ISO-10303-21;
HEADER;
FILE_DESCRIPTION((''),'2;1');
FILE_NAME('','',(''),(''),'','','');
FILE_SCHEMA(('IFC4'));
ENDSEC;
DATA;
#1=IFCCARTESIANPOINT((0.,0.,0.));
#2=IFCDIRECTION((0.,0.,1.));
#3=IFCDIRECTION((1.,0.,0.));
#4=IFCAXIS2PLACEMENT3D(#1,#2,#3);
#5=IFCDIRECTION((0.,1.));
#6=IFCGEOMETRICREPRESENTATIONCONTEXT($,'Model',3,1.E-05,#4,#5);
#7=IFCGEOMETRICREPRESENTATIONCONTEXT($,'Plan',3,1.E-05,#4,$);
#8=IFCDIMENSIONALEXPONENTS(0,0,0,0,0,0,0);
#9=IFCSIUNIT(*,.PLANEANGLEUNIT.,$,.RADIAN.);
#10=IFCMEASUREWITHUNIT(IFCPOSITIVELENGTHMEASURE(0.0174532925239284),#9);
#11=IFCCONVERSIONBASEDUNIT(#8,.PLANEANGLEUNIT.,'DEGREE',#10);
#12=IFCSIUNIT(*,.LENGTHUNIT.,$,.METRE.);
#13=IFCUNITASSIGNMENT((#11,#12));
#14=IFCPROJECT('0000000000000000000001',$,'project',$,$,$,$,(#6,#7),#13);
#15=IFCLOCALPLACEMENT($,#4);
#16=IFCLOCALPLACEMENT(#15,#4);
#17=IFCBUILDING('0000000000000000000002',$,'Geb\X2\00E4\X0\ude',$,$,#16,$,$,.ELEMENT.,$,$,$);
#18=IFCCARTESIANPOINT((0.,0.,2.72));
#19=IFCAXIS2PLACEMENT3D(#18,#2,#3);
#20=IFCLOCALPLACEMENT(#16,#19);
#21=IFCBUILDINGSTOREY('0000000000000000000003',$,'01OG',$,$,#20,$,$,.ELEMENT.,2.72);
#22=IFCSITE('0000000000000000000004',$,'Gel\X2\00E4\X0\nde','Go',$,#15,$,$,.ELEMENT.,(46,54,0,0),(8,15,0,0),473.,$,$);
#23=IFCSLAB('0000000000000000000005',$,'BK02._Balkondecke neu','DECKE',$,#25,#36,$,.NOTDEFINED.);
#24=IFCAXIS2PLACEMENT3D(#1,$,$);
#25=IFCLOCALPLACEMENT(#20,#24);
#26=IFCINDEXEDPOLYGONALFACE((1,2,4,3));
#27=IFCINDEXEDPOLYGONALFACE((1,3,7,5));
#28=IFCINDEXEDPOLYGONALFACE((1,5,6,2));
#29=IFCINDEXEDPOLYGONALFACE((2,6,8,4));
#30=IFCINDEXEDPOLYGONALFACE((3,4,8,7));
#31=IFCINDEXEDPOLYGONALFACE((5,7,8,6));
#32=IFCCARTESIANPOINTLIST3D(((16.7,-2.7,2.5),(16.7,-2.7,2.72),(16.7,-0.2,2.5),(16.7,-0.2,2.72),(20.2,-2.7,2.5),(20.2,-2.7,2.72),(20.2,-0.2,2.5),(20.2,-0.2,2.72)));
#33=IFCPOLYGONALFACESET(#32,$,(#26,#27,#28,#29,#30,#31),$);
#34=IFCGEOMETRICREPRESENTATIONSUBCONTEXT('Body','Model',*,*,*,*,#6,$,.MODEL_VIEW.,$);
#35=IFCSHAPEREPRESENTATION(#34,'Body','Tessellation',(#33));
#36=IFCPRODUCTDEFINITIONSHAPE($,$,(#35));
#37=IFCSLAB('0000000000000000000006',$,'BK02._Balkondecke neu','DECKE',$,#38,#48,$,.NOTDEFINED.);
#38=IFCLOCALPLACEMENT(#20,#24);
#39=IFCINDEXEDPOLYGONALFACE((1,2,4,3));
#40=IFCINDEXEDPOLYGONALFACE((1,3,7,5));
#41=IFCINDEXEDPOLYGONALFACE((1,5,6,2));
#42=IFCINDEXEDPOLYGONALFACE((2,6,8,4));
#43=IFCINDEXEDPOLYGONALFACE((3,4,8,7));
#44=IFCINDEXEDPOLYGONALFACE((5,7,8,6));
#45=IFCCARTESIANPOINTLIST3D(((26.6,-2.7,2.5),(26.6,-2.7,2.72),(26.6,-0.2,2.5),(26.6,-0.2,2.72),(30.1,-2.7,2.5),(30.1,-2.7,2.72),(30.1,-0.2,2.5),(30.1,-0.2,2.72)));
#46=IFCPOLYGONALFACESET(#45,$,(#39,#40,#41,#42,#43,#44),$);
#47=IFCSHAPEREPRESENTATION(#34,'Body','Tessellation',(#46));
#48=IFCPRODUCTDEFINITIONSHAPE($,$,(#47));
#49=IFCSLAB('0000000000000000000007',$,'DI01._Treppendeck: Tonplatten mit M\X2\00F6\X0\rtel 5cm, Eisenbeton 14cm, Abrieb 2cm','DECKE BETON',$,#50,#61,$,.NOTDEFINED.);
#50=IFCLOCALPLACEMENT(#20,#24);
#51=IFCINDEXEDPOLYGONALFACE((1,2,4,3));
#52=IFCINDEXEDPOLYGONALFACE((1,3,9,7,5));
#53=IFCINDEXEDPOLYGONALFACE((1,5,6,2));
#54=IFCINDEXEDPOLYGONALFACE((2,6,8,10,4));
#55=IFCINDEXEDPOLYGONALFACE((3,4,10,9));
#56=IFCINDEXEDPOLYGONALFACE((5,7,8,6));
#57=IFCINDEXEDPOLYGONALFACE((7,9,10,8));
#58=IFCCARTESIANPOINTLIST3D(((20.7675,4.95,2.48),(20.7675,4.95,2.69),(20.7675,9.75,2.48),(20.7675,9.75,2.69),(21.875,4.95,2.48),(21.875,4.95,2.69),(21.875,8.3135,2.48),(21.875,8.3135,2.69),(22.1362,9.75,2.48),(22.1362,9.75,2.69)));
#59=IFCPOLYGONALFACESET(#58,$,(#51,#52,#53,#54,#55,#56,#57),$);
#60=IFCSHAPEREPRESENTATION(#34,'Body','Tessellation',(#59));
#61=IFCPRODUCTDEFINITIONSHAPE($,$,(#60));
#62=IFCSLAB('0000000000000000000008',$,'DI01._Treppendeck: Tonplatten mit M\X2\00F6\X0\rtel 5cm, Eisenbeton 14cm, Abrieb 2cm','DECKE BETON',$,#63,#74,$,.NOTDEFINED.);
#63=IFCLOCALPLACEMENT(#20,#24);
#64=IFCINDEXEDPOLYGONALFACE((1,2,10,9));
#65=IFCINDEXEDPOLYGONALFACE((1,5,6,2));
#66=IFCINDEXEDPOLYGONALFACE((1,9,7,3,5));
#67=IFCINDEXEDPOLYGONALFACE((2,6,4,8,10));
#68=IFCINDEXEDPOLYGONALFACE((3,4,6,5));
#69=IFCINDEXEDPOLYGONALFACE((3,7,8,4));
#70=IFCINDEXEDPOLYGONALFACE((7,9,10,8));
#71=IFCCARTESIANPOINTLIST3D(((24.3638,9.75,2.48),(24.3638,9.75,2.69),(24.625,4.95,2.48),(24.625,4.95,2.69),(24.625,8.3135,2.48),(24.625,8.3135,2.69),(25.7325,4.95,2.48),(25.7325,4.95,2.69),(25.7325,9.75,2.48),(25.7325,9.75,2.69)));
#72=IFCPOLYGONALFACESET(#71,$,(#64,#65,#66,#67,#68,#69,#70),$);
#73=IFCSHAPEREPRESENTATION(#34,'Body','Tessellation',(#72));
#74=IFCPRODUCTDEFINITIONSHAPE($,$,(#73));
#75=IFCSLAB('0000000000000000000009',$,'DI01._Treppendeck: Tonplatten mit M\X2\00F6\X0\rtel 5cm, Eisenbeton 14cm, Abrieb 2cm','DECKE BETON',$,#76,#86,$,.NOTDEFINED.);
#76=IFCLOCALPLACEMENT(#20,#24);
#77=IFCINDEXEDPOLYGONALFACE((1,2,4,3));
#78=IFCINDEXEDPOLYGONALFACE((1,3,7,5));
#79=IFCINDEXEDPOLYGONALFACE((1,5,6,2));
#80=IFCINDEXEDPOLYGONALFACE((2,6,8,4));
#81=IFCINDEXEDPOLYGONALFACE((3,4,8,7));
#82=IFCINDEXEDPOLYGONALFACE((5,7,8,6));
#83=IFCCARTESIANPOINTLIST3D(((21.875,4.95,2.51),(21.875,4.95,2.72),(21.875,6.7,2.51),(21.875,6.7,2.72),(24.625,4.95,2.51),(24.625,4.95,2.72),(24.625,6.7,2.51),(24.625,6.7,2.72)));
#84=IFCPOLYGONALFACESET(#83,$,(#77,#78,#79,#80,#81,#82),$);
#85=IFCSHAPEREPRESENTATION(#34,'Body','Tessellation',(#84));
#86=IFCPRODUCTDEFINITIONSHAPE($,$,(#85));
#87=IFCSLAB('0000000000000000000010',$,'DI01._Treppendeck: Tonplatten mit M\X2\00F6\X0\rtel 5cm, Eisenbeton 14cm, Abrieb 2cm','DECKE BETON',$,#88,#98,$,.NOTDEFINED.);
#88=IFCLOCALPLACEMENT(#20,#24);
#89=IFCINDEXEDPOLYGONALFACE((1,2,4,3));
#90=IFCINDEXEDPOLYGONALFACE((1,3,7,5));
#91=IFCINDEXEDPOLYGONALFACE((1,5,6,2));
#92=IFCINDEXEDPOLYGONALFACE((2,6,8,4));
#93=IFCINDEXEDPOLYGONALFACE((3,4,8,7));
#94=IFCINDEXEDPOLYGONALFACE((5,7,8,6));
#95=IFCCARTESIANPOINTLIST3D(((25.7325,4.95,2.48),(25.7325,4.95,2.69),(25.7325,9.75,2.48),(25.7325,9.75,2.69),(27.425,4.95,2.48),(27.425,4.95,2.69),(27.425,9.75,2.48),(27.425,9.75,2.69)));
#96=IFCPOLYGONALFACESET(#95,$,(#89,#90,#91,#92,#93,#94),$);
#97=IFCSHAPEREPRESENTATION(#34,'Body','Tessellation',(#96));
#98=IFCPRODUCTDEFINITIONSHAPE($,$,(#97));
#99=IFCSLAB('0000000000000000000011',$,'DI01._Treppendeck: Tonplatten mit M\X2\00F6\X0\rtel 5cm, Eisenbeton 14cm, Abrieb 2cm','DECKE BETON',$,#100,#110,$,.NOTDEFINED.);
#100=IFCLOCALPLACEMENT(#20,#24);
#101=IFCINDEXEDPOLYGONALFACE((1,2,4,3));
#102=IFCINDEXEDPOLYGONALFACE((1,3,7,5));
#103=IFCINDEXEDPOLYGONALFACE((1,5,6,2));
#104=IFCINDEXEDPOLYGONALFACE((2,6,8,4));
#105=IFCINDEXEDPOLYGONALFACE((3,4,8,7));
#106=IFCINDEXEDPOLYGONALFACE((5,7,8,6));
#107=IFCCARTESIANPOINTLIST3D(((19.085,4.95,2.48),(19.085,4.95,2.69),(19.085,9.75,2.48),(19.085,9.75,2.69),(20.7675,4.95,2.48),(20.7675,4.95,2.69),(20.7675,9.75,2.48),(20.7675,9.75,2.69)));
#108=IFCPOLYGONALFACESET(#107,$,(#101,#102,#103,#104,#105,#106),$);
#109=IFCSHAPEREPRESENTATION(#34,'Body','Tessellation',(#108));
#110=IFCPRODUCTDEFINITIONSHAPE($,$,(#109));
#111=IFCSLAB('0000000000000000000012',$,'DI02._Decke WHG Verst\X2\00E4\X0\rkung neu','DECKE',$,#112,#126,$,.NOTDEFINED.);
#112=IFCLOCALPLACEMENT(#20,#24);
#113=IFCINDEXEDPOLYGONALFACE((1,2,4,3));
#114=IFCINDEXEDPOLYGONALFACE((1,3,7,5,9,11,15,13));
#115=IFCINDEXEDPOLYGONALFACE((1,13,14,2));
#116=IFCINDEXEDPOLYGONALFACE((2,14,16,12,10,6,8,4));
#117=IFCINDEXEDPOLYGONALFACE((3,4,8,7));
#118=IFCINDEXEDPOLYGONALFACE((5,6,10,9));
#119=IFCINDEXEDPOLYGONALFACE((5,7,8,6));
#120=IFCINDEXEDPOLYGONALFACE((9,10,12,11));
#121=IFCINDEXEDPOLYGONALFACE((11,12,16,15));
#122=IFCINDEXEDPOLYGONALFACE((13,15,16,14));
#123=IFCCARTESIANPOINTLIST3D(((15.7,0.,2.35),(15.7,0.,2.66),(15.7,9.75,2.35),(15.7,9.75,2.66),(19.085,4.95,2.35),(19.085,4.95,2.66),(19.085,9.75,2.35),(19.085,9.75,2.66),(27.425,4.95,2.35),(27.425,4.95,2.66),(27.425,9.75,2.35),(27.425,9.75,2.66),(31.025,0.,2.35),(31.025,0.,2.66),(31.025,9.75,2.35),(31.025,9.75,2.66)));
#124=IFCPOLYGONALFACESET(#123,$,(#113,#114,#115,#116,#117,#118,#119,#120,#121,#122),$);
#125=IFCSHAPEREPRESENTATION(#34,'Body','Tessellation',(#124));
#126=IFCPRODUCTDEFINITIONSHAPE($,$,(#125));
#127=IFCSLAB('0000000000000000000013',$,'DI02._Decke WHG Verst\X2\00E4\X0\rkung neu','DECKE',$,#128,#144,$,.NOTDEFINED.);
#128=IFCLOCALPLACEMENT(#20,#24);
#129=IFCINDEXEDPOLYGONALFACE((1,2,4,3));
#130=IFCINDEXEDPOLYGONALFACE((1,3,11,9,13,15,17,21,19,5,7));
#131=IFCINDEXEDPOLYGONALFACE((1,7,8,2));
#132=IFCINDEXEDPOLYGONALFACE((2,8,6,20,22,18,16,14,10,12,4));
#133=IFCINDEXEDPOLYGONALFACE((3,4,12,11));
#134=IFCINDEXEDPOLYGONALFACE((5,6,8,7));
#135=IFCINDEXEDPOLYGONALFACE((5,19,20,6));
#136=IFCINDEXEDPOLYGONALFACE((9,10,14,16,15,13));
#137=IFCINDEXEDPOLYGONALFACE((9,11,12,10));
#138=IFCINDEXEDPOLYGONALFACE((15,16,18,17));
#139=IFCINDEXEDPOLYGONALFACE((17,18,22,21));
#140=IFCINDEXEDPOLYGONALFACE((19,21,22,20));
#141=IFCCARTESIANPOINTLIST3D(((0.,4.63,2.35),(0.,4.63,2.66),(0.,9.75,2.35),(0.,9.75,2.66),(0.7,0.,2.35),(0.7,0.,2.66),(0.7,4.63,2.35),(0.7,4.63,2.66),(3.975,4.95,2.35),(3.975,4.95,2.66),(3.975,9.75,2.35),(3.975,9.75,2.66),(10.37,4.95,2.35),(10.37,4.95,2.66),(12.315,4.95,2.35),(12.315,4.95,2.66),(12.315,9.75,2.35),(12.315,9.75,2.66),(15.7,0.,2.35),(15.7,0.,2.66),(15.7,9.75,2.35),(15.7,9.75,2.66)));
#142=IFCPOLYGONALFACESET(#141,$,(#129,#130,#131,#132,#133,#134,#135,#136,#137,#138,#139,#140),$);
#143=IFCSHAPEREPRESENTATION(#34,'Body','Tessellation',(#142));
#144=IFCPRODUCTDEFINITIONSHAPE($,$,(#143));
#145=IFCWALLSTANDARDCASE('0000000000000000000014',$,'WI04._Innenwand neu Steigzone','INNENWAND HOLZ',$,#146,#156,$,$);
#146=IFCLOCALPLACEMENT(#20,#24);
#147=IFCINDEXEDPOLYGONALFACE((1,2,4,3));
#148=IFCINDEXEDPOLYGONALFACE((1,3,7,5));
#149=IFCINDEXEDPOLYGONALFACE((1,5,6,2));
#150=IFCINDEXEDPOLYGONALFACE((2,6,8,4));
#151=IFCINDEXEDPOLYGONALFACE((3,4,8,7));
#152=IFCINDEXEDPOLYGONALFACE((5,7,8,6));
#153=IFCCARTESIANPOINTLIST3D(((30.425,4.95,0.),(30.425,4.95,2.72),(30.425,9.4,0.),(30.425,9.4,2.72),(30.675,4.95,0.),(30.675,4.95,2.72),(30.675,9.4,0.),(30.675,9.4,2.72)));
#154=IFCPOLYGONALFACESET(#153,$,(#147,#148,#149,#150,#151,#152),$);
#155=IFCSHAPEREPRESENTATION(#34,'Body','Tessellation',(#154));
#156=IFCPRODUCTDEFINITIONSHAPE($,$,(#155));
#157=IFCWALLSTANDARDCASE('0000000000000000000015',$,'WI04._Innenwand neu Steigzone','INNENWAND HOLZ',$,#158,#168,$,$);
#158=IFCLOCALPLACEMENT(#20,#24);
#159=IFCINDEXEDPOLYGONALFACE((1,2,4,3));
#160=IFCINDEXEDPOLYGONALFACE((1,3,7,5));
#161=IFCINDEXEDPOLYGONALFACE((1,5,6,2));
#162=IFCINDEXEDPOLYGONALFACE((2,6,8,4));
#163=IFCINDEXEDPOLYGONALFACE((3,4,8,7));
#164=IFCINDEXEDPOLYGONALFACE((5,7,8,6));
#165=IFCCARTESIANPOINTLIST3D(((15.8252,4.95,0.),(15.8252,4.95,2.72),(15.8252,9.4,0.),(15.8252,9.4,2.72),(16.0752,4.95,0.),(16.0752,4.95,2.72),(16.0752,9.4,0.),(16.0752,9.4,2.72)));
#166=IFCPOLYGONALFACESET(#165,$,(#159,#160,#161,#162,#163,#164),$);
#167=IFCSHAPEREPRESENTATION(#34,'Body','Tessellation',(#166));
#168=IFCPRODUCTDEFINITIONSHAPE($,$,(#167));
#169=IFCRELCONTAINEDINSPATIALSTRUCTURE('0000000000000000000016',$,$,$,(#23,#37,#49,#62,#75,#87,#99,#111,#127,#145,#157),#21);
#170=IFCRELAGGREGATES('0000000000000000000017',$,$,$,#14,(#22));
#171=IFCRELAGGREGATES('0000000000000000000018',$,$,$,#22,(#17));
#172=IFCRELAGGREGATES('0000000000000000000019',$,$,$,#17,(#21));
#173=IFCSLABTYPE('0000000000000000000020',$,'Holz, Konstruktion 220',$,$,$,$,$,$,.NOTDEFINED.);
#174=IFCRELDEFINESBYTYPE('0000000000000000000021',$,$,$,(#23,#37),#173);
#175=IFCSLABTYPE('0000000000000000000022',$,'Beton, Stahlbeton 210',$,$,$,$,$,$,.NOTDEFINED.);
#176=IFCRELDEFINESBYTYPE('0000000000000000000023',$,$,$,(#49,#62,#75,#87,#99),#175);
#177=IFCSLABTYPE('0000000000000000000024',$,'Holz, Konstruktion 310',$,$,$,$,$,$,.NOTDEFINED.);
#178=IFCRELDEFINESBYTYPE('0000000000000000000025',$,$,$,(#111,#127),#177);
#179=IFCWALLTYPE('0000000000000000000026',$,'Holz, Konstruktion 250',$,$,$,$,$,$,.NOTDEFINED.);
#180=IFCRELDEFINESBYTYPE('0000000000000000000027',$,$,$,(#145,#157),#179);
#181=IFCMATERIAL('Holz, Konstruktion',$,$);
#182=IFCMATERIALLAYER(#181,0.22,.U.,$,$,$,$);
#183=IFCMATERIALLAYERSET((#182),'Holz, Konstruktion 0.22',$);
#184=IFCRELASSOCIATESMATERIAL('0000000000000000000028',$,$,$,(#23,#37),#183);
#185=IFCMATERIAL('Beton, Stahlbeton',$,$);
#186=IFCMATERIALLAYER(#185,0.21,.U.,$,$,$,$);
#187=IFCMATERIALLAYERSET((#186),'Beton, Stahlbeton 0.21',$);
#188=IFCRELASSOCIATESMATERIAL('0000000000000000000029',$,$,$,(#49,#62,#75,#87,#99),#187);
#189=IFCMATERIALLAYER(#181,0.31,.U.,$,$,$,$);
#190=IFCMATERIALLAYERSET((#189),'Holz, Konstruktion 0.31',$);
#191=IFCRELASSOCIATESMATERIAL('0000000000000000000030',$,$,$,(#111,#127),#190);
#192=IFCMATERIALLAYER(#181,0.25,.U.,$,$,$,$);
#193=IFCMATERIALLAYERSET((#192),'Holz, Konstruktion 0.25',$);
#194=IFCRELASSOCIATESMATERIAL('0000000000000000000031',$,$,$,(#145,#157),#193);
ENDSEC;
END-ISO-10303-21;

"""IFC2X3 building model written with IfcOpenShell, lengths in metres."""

from ifc_helpers import new_model, entity, si_unit, converted_unit, direction, frame, origin_with_axes, place, context, subcontext, project, spatial, polyline, outline, extrude, material, layer, layer_set, layer_usage, type_object, element, save


model = new_model("IFC2X3")

# Units and contexts
model_context = context("Model", 3, precision=1e-05, world=origin_with_axes(), true_north=direction((0.0, 1.0)))
plan_context = context("Plan", 3, precision=1e-05, world=origin_with_axes())
body_context = subcontext(model_context, "Body", "Model", "MODEL_VIEW")
ifc_project = project(units=[converted_unit("PLANEANGLEUNIT", "DEGREE", entity("IfcPositiveLengthMeasure", 0.0174532925239284), si_unit("PLANEANGLEUNIT", "RADIAN"), dimensions=[0, 0, 0, 0, 0, 0, 0]), si_unit("LENGTHUNIT", "METRE")], contexts=[model_context, plan_context])

# Site, building, storey
site_placement = place(None, origin_with_axes())
site = spatial("IfcSite", under=ifc_project, at=site_placement, Name="Gelände", Description="Go", CompositionType="ELEMENT", RefLatitude=(46, 54, 0, 0), RefLongitude=(8, 15, 0, 0), RefElevation=473.0)
building_placement = place(site_placement, origin_with_axes())
building = spatial("IfcBuilding", under=site, at=building_placement, Name="Gebäude", CompositionType="ELEMENT")
storey_placement = place(building_placement, frame((0.0, 0.0, 2.72), z_axis=(0.0, 0.0, 1.0), x_axis=(1.0, 0.0, 0.0)))
storey = spatial("IfcBuildingStorey", under=building, at=storey_placement, Name="01OG", CompositionType="ELEMENT", Elevation=2.72)

# Slabs
ifc_material_1 = material(Name="Holz, Konstruktion")
ifc_layer_1 = layer(ifc_material_1, 0.22, ventilated="UNKNOWN")
ifc_layer_set_1 = layer_set([ifc_layer_1], Name="Holz, Konstruktion 0.22")
ifc_layer_usage_1 = layer_usage(ifc_layer_set_1, "AXIS3", "NEGATIVE", 0.22)
slab_type_1 = type_object("IfcSlabType", Name="Holz, Konstruktion 220", PredefinedType="NOTDEFINED")
slab_1_placement = place(storey_placement, frame((16.7, -2.7, 2.72), z_axis=(0.0, 0.0, 1.0), x_axis=(1.0, 0.0, 0.0)))
element("IfcSlab", 1, at=slab_1_placement, inside=storey, type_object=slab_type_1, material=ifc_layer_usage_1, Name="BK02._Balkondecke neu", Description="DECKE", PredefinedType="NOTDEFINED", context=body_context, shape_type="SweptSolid", body=[
    extrude(outline(polyline([(0.0, 0.0), (3.5, 0.0), (3.5, 2.5), (0.0, 2.5), (0.0, 0.0)])), frame((0.0, 0.0, -0.22), z_axis=(0.0, 0.0, 1.0), x_axis=(1.0, 0.0, 0.0)), (0.0, 0.0, 1.0), 0.22),
])
ifc_layer_usage_2 = layer_usage(ifc_layer_set_1, "AXIS3", "NEGATIVE", 0.22)
slab_2_placement = place(storey_placement, frame((26.6, -2.7, 2.72), z_axis=(0.0, 0.0, 1.0), x_axis=(1.0, 0.0, 0.0)))
element("IfcSlab", 2, at=slab_2_placement, inside=storey, type_object=slab_type_1, material=ifc_layer_usage_2, Name="BK02._Balkondecke neu", Description="DECKE", PredefinedType="NOTDEFINED", context=body_context, shape_type="SweptSolid", body=[
    extrude(outline(polyline([(0.0, 0.0), (3.5, 0.0), (3.5, 2.5), (0.0, 2.5), (0.0, 0.0)])), frame((0.0, 0.0, -0.22), z_axis=(0.0, 0.0, 1.0), x_axis=(1.0, 0.0, 0.0)), (0.0, 0.0, 1.0), 0.22),
])
ifc_material_2 = material(Name="Beton, Stahlbeton")
ifc_layer_2 = layer(ifc_material_2, 0.21, ventilated="UNKNOWN")
ifc_layer_set_2 = layer_set([ifc_layer_2], Name="Beton, Stahlbeton 0.21")
ifc_layer_usage_3 = layer_usage(ifc_layer_set_2, "AXIS3", "NEGATIVE", 0.21)
slab_type_2 = type_object("IfcSlabType", Name="Beton, Stahlbeton 210", PredefinedType="NOTDEFINED")
slab_3_placement = place(storey_placement, frame((20.7675, 4.95, 2.69), z_axis=(0.0, 0.0, 1.0), x_axis=(1.0, 0.0, 0.0)))
element("IfcSlab", 3, at=slab_3_placement, inside=storey, type_object=slab_type_2, material=ifc_layer_usage_3, Name="DI01._Treppendeck: Tonplatten mit Mörtel 5cm, Eisenbeton 14cm, Abrieb 2cm", Description="DECKE BETON", PredefinedType="NOTDEFINED", context=body_context, shape_type="SweptSolid", body=[
    extrude(outline(polyline([(0.0, 0.0), (1.1075, 0.0), (1.1075, 3.3635), (1.3687, 4.8), (0.0, 4.8), (0.0, 0.0)])), frame((0.0, 0.0, -0.21), z_axis=(0.0, 0.0, 1.0), x_axis=(1.0, 0.0, 0.0)), (0.0, 0.0, 1.0), 0.21),
])
ifc_layer_usage_4 = layer_usage(ifc_layer_set_2, "AXIS3", "NEGATIVE", 0.21)
slab_4_placement = place(storey_placement, frame((24.625, 4.95, 2.69), z_axis=(0.0, 0.0, 1.0), x_axis=(1.0, 0.0, 0.0)))
element("IfcSlab", 4, at=slab_4_placement, inside=storey, type_object=slab_type_2, material=ifc_layer_usage_4, Name="DI01._Treppendeck: Tonplatten mit Mörtel 5cm, Eisenbeton 14cm, Abrieb 2cm", Description="DECKE BETON", PredefinedType="NOTDEFINED", context=body_context, shape_type="SweptSolid", body=[
    extrude(outline(polyline([(0.0, 0.0), (1.1075, 0.0), (1.1075, 4.8), (-0.2612, 4.8), (0.0, 3.3635), (0.0, 0.0)])), frame((0.0, 0.0, -0.21), z_axis=(0.0, 0.0, 1.0), x_axis=(1.0, 0.0, 0.0)), (0.0, 0.0, 1.0), 0.21),
])
ifc_layer_usage_5 = layer_usage(ifc_layer_set_2, "AXIS3", "NEGATIVE", 0.21)
slab_5_placement = place(storey_placement, frame((21.875, 4.95, 2.72), z_axis=(0.0, 0.0, 1.0), x_axis=(1.0, 0.0, 0.0)))
element("IfcSlab", 5, at=slab_5_placement, inside=storey, type_object=slab_type_2, material=ifc_layer_usage_5, Name="DI01._Treppendeck: Tonplatten mit Mörtel 5cm, Eisenbeton 14cm, Abrieb 2cm", Description="DECKE BETON", PredefinedType="NOTDEFINED", context=body_context, shape_type="SweptSolid", body=[
    extrude(outline(polyline([(0.0, 0.0), (2.75, 0.0), (2.75, 1.75), (0.0, 1.75), (0.0, 0.0)])), frame((0.0, 0.0, -0.21), z_axis=(0.0, 0.0, 1.0), x_axis=(1.0, 0.0, 0.0)), (0.0, 0.0, 1.0), 0.21),
])
ifc_layer_usage_6 = layer_usage(ifc_layer_set_2, "AXIS3", "NEGATIVE", 0.21)
slab_6_placement = place(storey_placement, frame((25.7325, 4.95, 2.69), z_axis=(0.0, 0.0, 1.0), x_axis=(1.0, 0.0, 0.0)))
element("IfcSlab", 6, at=slab_6_placement, inside=storey, type_object=slab_type_2, material=ifc_layer_usage_6, Name="DI01._Treppendeck: Tonplatten mit Mörtel 5cm, Eisenbeton 14cm, Abrieb 2cm", Description="DECKE BETON", PredefinedType="NOTDEFINED", context=body_context, shape_type="SweptSolid", body=[
    extrude(outline(polyline([(0.0, 0.0), (1.6925, 0.0), (1.6925, 4.8), (0.0, 4.8), (0.0, 0.0)])), frame((0.0, 0.0, -0.21), z_axis=(0.0, 0.0, 1.0), x_axis=(1.0, 0.0, 0.0)), (0.0, 0.0, 1.0), 0.21),
])
ifc_layer_usage_7 = layer_usage(ifc_layer_set_2, "AXIS3", "NEGATIVE", 0.21)
slab_7_placement = place(storey_placement, frame((19.085, 4.95, 2.69), z_axis=(0.0, 0.0, 1.0), x_axis=(1.0, 0.0, 0.0)))
element("IfcSlab", 7, at=slab_7_placement, inside=storey, type_object=slab_type_2, material=ifc_layer_usage_7, Name="DI01._Treppendeck: Tonplatten mit Mörtel 5cm, Eisenbeton 14cm, Abrieb 2cm", Description="DECKE BETON", PredefinedType="NOTDEFINED", context=body_context, shape_type="SweptSolid", body=[
    extrude(outline(polyline([(0.0, 0.0), (1.6825, 0.0), (1.6825, 4.8), (0.0, 4.8), (0.0, 0.0)])), frame((0.0, 0.0, -0.21), z_axis=(0.0, 0.0, 1.0), x_axis=(1.0, 0.0, 0.0)), (0.0, 0.0, 1.0), 0.21),
])
ifc_layer_3 = layer(ifc_material_1, 0.31, ventilated="UNKNOWN")
ifc_layer_set_3 = layer_set([ifc_layer_3], Name="Holz, Konstruktion 0.31")
ifc_layer_usage_8 = layer_usage(ifc_layer_set_3, "AXIS3", "NEGATIVE", 0.31)
slab_type_3 = type_object("IfcSlabType", Name="Holz, Konstruktion 310", PredefinedType="NOTDEFINED")
slab_8_placement = place(storey_placement, frame((15.7, 0.0, 2.66), z_axis=(0.0, 0.0, 1.0), x_axis=(1.0, 0.0, 0.0)))
element("IfcSlab", 8, at=slab_8_placement, inside=storey, type_object=slab_type_3, material=ifc_layer_usage_8, Name="DI02._Decke WHG Verstärkung neu", Description="DECKE", PredefinedType="NOTDEFINED", context=body_context, shape_type="SweptSolid", body=[
    extrude(outline(polyline([(0.0, 0.0), (15.325, 0.0), (15.325, 9.75), (11.725, 9.75), (11.725, 4.95), (3.385, 4.95), (3.385, 9.75), (0.0, 9.75), (0.0, 0.0)])), frame((0.0, 0.0, -0.31), z_axis=(0.0, 0.0, 1.0), x_axis=(1.0, 0.0, 0.0)), (0.0, 0.0, 1.0), 0.31),
])
ifc_layer_usage_9 = layer_usage(ifc_layer_set_3, "AXIS3", "NEGATIVE", 0.31)
slab_9_placement = place(storey_placement, frame((15.7, 0.0, 2.66), z_axis=(0.0, 0.0, 1.0), x_axis=(1.0, 0.0, 0.0)))
element("IfcSlab", 9, at=slab_9_placement, inside=storey, type_object=slab_type_3, material=ifc_layer_usage_9, Name="DI02._Decke WHG Verstärkung neu", Description="DECKE", PredefinedType="NOTDEFINED", context=body_context, shape_type="SweptSolid", body=[
    extrude(outline(polyline([(0.0, 0.0), (0.0, 9.75), (-3.385, 9.75), (-3.385, 4.95), (-5.33, 4.95), (-11.725, 4.95), (-11.725, 9.75), (-15.7, 9.75), (-15.7, 4.63), (-15.0, 4.63), (-15.0, 0.0), (0.0, 0.0)])), frame((0.0, 0.0, -0.31), z_axis=(0.0, 0.0, 1.0), x_axis=(1.0, 0.0, 0.0)), (0.0, 0.0, 1.0), 0.31),
])

# Walls
ifc_layer_4 = layer(ifc_material_1, 0.25, ventilated="UNKNOWN")
ifc_layer_set_4 = layer_set([ifc_layer_4], Name="Holz, Konstruktion 0.25")
ifc_layer_usage_10 = layer_usage(ifc_layer_set_4, "AXIS2", "NEGATIVE", 0.0)
wall_type_1 = type_object("IfcWallType", Name="Holz, Konstruktion 250", PredefinedType="NOTDEFINED")
wall_1_placement = place(storey_placement, frame((30.425, 4.95, 0.0), z_axis=(0.0, 0.0, 1.0), x_axis=(0.0, 1.0, 0.0)))
element("IfcWallStandardCase", 10, at=wall_1_placement, inside=storey, type_object=wall_type_1, material=ifc_layer_usage_10, Name="WI04._Innenwand neu Steigzone", Description="INNENWAND HOLZ", context=body_context, shape_type="SweptSolid", body=[
    extrude(outline(polyline([(0.0, -0.25), (4.45, -0.25), (4.45, 0.0), (0.0, 0.0), (0.0, -0.25)])), origin_with_axes(), (0.0, 0.0, 1.0), 2.72),
])
ifc_layer_usage_11 = layer_usage(ifc_layer_set_4, "AXIS2", "POSITIVE", 0.0)
wall_2_placement = place(storey_placement, frame((16.0752, 4.95, 0.0), z_axis=(0.0, 0.0, 1.0), x_axis=(0.0, 1.0, 0.0)))
element("IfcWallStandardCase", 11, at=wall_2_placement, inside=storey, type_object=wall_type_1, material=ifc_layer_usage_11, Name="WI04._Innenwand neu Steigzone", Description="INNENWAND HOLZ", context=body_context, shape_type="SweptSolid", body=[
    extrude(outline(polyline([(0.0, 0.0), (4.45, 0.0), (4.45, 0.25), (0.0, 0.25), (0.0, 0.0)])), origin_with_axes(), (0.0, 0.0, 1.0), 2.72),
])

save(model, "model.ifc")
